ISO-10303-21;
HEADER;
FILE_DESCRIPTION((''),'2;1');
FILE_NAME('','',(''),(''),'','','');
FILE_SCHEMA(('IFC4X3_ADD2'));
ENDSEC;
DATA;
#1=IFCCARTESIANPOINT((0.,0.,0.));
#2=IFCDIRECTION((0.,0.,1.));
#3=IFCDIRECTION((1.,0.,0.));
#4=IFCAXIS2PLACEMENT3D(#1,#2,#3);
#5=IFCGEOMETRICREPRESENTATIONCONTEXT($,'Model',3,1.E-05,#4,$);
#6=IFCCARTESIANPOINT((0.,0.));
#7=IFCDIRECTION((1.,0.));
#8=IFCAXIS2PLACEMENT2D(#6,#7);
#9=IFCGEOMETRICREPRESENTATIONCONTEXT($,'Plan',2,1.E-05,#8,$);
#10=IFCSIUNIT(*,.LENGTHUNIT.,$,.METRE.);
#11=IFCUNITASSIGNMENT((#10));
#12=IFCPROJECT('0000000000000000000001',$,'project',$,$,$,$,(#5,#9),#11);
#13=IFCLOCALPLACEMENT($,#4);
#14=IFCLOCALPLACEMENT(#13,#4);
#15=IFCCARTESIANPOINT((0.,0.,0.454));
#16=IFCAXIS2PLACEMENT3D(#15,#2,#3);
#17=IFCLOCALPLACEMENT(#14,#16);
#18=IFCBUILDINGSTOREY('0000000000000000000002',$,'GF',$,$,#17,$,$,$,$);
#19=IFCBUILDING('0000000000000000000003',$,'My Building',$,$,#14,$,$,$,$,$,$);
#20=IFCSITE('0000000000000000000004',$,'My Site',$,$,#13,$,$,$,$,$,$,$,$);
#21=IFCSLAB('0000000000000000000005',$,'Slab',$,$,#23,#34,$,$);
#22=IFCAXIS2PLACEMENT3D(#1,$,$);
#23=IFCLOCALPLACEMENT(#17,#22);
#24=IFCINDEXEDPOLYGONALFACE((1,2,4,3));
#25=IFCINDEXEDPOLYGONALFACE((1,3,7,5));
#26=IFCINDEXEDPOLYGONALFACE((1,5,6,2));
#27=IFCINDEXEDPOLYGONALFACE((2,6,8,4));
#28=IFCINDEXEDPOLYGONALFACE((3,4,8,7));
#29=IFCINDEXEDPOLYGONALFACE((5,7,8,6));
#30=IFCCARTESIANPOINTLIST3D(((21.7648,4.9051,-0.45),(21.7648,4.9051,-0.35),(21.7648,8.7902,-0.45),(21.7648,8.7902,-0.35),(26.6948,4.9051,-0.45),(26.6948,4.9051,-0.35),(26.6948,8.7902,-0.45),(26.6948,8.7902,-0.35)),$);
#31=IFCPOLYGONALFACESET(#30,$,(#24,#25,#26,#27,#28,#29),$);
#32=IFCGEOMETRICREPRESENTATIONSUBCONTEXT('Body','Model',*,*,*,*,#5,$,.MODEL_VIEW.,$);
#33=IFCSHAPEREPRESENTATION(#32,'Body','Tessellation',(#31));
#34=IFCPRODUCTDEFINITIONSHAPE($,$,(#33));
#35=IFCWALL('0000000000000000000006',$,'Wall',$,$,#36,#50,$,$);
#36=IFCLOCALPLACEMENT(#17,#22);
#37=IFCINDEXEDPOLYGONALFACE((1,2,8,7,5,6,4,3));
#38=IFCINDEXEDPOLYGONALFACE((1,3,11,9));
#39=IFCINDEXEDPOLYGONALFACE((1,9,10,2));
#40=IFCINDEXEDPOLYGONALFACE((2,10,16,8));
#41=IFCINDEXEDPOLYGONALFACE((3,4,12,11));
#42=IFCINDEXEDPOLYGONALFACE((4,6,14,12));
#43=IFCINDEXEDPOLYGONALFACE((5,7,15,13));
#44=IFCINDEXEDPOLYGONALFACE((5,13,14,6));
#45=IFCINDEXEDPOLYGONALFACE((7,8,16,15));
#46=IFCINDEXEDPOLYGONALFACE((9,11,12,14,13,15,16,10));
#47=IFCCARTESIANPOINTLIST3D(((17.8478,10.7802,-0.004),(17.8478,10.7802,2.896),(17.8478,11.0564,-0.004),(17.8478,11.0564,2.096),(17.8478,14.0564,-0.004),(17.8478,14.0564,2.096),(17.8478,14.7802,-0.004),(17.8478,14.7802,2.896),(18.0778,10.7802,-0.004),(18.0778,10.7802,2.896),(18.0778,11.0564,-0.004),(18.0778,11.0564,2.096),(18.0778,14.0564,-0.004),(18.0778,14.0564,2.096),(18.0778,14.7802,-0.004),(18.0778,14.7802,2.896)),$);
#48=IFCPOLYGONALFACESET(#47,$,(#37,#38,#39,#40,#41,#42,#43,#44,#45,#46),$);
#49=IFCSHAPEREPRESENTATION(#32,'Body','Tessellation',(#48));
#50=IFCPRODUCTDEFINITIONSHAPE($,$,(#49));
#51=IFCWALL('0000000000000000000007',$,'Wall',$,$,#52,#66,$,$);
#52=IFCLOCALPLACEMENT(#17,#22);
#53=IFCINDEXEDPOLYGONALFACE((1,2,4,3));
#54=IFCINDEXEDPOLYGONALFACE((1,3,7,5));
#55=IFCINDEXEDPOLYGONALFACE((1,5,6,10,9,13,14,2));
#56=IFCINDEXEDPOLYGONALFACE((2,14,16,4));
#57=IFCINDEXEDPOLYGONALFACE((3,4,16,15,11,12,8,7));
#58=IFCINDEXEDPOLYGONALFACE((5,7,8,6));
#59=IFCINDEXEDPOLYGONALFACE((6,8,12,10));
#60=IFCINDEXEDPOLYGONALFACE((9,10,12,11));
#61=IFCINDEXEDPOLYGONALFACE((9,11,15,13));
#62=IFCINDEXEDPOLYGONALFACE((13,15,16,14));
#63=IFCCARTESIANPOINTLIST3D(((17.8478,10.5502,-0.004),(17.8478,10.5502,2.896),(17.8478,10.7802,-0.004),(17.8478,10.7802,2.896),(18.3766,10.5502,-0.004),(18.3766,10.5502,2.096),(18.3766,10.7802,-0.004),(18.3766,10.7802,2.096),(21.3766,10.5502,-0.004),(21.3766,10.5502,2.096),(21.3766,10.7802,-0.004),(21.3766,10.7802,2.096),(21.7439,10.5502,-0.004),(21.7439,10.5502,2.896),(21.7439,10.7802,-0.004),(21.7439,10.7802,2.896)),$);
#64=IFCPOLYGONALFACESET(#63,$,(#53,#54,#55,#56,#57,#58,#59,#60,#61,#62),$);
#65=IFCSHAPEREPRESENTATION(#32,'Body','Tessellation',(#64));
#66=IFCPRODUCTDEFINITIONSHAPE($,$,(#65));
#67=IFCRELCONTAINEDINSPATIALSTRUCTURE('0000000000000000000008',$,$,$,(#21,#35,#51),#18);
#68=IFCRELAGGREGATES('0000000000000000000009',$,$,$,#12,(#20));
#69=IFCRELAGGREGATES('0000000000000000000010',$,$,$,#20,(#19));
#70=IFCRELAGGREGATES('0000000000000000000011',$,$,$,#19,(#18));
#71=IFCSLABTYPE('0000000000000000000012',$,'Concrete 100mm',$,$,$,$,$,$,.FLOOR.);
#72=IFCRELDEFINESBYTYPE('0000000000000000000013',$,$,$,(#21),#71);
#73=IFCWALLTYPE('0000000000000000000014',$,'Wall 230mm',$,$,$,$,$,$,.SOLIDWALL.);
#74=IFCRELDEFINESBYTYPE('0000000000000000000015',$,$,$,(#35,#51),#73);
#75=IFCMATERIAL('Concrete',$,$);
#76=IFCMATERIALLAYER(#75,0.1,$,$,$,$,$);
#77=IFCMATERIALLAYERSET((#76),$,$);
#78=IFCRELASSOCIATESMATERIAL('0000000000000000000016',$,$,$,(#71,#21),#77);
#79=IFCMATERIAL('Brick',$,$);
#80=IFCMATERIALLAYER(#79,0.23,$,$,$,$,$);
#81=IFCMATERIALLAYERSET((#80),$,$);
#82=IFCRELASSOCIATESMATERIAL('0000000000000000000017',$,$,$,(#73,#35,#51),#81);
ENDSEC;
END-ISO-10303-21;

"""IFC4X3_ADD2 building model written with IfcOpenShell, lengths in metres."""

from ifc_helpers import new_model, si_unit, frame, origin_with_axes, origin_2d_with_axis, place, context, subcontext, project, spatial, line, indexed_curve, outline, extrude, source, transform, mapped, material, layer, layer_set, layer_usage, type_object, element, save


model = new_model("IFC4X3_ADD2")

# Units and contexts
model_context = context("Model", 3, precision=1e-05, world=origin_with_axes())
plan_context = context("Plan", 2, precision=1e-05, world=origin_2d_with_axis())
body_context_1 = subcontext(model_context, "Body", "Model", "MODEL_VIEW")
ifc_project = project(units=[si_unit("LENGTHUNIT", "METRE")], contexts=[model_context, plan_context])

# Site, building, storey
site_placement = place(None, origin_with_axes())
site = spatial("IfcSite", under=ifc_project, at=site_placement, Name="My Site")
building_placement = place(site_placement, origin_with_axes())
building = spatial("IfcBuilding", under=site, at=building_placement, Name="My Building")
storey_placement = place(building_placement, frame((0.0, 0.0, 0.454), z_axis=(0.0, 0.0, 1.0), x_axis=(1.0, 0.0, 0.0)))
storey = spatial("IfcBuildingStorey", under=building, at=storey_placement, Name="GF")

# Shared definitions
ifc_material_1 = material(Name="Concrete")

# Slab
ifc_layer_1 = layer(ifc_material_1, 0.1)
ifc_layer_set_1 = layer_set([ifc_layer_1])
ifc_layer_usage_1 = layer_usage(ifc_layer_set_1, "AXIS3", "POSITIVE", 0.0)
slab_type = type_object("IfcSlabType", Name="Concrete 100mm", PredefinedType="FLOOR", material=ifc_layer_set_1)
slab_placement = place(storey_placement, frame((21.7648, 4.9051, -0.45), z_axis=(0.0, 0.0, 1.0), x_axis=(1.0, 0.0, 0.0)))
element("IfcSlab", 1, at=slab_placement, inside=storey, type_object=slab_type, material=ifc_layer_usage_1, Name="Slab", context=body_context_1, shape_type="SweptSolid", body=[
    extrude(outline(indexed_curve([(4.93, 3.8851), (4.93, 0.0), (0.0, 0.0), (0.0, 3.8851)], segments=[line(4, 1), line(1, 2), line(2, 3), line(3, 4)], self_intersect=False)), None, (0.0, 0.0, 1.0), 0.1),
])

# Walls, openings
ifc_material_2 = material(Name="Brick")
ifc_layer_2 = layer(ifc_material_2, 0.23)
ifc_layer_set_2 = layer_set([ifc_layer_2])
ifc_layer_usage_2 = layer_usage(ifc_layer_set_2, "AXIS2", "POSITIVE", 0.0)
wall_type = type_object("IfcWallType", Name="Wall 230mm", PredefinedType="SOLIDWALL", material=ifc_layer_set_2)
wall_1_placement = place(storey_placement, frame((18.0778, 10.7802, -0.004), z_axis=(0.0, 0.0, 1.0), x_axis=(0.000001, 1.0, 0.0)))
wall_1 = element("IfcWall", 2, at=wall_1_placement, inside=storey, type_object=wall_type, material=ifc_layer_usage_2, Name="Wall", context=body_context_1, shape_type="SweptSolid", body=[
    extrude(outline(indexed_curve([(0.0, 0.0), (0.0, 0.23), (4.0, 0.23), (4.0, 0.0), (0.0, 0.0)], self_intersect=False)), origin_with_axes(), (0.0, 0.0, 1.0), 2.9),
])
shared_shape_1 = source(origin_with_axes(), body_context_1, "Body", "SweptSolid", [
    extrude(outline(indexed_curve([(0.0, 0.0), (3.0, 0.0), (3.0, 2.1), (0.0, 2.1)], segments=[line(1, 2, 3, 4, 1)])), frame((0.0, -0.6, 0.0), z_axis=(0.0, -1.0, 0.0), x_axis=(1.0, 0.0, 0.0)), (0.0, 0.0, -1.0), 1.2),
])
opening_1_placement = place(wall_1_placement, frame((0.2763, 0.0, 0.0), z_axis=(0.0, 0.0, 1.0), x_axis=(1.0, 0.0, 0.0)))
element("IfcOpeningElement", 3, at=opening_1_placement, cuts=wall_1, PredefinedType="OPENING", context=body_context_1, shape_type="MappedRepresentation", body=[
    mapped(shared_shape_1, transform((0.0, 0.0, 0.0), x_axis=(1.0, 0.0, 0.0), y_axis=(0.0, 1.0, 0.0), z_axis=(0.0, 0.0, 1.0), scale=1.0)),
])
ifc_layer_usage_3 = layer_usage(ifc_layer_set_2, "AXIS2", "POSITIVE", 0.0)
wall_2_placement = place(storey_placement, frame((21.7439, 10.7802, -0.004), z_axis=(0.0, 0.0, 1.0), x_axis=(-1.0, 0.0, 0.0)))
wall_2 = element("IfcWall", 4, at=wall_2_placement, inside=storey, type_object=wall_type, material=ifc_layer_usage_3, Name="Wall", context=body_context_1, shape_type="SweptSolid", body=[
    extrude(outline(indexed_curve([(0.0, 0.0), (0.0, 0.23), (3.8962, 0.23), (3.8962, 0.0), (0.0, 0.0)], self_intersect=False)), origin_with_axes(), (0.0, 0.0, 1.0), 2.9),
])
opening_2_placement = place(wall_2_placement, frame((0.3674, 0.0, 0.0), z_axis=(0.0, 0.0, 1.0), x_axis=(1.0, 0.0, 0.0)))
element("IfcOpeningElement", 5, at=opening_2_placement, cuts=wall_2, PredefinedType="OPENING", context=body_context_1, shape_type="MappedRepresentation", body=[
    mapped(shared_shape_1, transform((0.0, 0.0, 0.0), x_axis=(1.0, 0.0, 0.0), y_axis=(0.0, 1.0, 0.0), z_axis=(0.0, 0.0, 1.0), scale=1.0)),
])

save(model, "model.ifc")
